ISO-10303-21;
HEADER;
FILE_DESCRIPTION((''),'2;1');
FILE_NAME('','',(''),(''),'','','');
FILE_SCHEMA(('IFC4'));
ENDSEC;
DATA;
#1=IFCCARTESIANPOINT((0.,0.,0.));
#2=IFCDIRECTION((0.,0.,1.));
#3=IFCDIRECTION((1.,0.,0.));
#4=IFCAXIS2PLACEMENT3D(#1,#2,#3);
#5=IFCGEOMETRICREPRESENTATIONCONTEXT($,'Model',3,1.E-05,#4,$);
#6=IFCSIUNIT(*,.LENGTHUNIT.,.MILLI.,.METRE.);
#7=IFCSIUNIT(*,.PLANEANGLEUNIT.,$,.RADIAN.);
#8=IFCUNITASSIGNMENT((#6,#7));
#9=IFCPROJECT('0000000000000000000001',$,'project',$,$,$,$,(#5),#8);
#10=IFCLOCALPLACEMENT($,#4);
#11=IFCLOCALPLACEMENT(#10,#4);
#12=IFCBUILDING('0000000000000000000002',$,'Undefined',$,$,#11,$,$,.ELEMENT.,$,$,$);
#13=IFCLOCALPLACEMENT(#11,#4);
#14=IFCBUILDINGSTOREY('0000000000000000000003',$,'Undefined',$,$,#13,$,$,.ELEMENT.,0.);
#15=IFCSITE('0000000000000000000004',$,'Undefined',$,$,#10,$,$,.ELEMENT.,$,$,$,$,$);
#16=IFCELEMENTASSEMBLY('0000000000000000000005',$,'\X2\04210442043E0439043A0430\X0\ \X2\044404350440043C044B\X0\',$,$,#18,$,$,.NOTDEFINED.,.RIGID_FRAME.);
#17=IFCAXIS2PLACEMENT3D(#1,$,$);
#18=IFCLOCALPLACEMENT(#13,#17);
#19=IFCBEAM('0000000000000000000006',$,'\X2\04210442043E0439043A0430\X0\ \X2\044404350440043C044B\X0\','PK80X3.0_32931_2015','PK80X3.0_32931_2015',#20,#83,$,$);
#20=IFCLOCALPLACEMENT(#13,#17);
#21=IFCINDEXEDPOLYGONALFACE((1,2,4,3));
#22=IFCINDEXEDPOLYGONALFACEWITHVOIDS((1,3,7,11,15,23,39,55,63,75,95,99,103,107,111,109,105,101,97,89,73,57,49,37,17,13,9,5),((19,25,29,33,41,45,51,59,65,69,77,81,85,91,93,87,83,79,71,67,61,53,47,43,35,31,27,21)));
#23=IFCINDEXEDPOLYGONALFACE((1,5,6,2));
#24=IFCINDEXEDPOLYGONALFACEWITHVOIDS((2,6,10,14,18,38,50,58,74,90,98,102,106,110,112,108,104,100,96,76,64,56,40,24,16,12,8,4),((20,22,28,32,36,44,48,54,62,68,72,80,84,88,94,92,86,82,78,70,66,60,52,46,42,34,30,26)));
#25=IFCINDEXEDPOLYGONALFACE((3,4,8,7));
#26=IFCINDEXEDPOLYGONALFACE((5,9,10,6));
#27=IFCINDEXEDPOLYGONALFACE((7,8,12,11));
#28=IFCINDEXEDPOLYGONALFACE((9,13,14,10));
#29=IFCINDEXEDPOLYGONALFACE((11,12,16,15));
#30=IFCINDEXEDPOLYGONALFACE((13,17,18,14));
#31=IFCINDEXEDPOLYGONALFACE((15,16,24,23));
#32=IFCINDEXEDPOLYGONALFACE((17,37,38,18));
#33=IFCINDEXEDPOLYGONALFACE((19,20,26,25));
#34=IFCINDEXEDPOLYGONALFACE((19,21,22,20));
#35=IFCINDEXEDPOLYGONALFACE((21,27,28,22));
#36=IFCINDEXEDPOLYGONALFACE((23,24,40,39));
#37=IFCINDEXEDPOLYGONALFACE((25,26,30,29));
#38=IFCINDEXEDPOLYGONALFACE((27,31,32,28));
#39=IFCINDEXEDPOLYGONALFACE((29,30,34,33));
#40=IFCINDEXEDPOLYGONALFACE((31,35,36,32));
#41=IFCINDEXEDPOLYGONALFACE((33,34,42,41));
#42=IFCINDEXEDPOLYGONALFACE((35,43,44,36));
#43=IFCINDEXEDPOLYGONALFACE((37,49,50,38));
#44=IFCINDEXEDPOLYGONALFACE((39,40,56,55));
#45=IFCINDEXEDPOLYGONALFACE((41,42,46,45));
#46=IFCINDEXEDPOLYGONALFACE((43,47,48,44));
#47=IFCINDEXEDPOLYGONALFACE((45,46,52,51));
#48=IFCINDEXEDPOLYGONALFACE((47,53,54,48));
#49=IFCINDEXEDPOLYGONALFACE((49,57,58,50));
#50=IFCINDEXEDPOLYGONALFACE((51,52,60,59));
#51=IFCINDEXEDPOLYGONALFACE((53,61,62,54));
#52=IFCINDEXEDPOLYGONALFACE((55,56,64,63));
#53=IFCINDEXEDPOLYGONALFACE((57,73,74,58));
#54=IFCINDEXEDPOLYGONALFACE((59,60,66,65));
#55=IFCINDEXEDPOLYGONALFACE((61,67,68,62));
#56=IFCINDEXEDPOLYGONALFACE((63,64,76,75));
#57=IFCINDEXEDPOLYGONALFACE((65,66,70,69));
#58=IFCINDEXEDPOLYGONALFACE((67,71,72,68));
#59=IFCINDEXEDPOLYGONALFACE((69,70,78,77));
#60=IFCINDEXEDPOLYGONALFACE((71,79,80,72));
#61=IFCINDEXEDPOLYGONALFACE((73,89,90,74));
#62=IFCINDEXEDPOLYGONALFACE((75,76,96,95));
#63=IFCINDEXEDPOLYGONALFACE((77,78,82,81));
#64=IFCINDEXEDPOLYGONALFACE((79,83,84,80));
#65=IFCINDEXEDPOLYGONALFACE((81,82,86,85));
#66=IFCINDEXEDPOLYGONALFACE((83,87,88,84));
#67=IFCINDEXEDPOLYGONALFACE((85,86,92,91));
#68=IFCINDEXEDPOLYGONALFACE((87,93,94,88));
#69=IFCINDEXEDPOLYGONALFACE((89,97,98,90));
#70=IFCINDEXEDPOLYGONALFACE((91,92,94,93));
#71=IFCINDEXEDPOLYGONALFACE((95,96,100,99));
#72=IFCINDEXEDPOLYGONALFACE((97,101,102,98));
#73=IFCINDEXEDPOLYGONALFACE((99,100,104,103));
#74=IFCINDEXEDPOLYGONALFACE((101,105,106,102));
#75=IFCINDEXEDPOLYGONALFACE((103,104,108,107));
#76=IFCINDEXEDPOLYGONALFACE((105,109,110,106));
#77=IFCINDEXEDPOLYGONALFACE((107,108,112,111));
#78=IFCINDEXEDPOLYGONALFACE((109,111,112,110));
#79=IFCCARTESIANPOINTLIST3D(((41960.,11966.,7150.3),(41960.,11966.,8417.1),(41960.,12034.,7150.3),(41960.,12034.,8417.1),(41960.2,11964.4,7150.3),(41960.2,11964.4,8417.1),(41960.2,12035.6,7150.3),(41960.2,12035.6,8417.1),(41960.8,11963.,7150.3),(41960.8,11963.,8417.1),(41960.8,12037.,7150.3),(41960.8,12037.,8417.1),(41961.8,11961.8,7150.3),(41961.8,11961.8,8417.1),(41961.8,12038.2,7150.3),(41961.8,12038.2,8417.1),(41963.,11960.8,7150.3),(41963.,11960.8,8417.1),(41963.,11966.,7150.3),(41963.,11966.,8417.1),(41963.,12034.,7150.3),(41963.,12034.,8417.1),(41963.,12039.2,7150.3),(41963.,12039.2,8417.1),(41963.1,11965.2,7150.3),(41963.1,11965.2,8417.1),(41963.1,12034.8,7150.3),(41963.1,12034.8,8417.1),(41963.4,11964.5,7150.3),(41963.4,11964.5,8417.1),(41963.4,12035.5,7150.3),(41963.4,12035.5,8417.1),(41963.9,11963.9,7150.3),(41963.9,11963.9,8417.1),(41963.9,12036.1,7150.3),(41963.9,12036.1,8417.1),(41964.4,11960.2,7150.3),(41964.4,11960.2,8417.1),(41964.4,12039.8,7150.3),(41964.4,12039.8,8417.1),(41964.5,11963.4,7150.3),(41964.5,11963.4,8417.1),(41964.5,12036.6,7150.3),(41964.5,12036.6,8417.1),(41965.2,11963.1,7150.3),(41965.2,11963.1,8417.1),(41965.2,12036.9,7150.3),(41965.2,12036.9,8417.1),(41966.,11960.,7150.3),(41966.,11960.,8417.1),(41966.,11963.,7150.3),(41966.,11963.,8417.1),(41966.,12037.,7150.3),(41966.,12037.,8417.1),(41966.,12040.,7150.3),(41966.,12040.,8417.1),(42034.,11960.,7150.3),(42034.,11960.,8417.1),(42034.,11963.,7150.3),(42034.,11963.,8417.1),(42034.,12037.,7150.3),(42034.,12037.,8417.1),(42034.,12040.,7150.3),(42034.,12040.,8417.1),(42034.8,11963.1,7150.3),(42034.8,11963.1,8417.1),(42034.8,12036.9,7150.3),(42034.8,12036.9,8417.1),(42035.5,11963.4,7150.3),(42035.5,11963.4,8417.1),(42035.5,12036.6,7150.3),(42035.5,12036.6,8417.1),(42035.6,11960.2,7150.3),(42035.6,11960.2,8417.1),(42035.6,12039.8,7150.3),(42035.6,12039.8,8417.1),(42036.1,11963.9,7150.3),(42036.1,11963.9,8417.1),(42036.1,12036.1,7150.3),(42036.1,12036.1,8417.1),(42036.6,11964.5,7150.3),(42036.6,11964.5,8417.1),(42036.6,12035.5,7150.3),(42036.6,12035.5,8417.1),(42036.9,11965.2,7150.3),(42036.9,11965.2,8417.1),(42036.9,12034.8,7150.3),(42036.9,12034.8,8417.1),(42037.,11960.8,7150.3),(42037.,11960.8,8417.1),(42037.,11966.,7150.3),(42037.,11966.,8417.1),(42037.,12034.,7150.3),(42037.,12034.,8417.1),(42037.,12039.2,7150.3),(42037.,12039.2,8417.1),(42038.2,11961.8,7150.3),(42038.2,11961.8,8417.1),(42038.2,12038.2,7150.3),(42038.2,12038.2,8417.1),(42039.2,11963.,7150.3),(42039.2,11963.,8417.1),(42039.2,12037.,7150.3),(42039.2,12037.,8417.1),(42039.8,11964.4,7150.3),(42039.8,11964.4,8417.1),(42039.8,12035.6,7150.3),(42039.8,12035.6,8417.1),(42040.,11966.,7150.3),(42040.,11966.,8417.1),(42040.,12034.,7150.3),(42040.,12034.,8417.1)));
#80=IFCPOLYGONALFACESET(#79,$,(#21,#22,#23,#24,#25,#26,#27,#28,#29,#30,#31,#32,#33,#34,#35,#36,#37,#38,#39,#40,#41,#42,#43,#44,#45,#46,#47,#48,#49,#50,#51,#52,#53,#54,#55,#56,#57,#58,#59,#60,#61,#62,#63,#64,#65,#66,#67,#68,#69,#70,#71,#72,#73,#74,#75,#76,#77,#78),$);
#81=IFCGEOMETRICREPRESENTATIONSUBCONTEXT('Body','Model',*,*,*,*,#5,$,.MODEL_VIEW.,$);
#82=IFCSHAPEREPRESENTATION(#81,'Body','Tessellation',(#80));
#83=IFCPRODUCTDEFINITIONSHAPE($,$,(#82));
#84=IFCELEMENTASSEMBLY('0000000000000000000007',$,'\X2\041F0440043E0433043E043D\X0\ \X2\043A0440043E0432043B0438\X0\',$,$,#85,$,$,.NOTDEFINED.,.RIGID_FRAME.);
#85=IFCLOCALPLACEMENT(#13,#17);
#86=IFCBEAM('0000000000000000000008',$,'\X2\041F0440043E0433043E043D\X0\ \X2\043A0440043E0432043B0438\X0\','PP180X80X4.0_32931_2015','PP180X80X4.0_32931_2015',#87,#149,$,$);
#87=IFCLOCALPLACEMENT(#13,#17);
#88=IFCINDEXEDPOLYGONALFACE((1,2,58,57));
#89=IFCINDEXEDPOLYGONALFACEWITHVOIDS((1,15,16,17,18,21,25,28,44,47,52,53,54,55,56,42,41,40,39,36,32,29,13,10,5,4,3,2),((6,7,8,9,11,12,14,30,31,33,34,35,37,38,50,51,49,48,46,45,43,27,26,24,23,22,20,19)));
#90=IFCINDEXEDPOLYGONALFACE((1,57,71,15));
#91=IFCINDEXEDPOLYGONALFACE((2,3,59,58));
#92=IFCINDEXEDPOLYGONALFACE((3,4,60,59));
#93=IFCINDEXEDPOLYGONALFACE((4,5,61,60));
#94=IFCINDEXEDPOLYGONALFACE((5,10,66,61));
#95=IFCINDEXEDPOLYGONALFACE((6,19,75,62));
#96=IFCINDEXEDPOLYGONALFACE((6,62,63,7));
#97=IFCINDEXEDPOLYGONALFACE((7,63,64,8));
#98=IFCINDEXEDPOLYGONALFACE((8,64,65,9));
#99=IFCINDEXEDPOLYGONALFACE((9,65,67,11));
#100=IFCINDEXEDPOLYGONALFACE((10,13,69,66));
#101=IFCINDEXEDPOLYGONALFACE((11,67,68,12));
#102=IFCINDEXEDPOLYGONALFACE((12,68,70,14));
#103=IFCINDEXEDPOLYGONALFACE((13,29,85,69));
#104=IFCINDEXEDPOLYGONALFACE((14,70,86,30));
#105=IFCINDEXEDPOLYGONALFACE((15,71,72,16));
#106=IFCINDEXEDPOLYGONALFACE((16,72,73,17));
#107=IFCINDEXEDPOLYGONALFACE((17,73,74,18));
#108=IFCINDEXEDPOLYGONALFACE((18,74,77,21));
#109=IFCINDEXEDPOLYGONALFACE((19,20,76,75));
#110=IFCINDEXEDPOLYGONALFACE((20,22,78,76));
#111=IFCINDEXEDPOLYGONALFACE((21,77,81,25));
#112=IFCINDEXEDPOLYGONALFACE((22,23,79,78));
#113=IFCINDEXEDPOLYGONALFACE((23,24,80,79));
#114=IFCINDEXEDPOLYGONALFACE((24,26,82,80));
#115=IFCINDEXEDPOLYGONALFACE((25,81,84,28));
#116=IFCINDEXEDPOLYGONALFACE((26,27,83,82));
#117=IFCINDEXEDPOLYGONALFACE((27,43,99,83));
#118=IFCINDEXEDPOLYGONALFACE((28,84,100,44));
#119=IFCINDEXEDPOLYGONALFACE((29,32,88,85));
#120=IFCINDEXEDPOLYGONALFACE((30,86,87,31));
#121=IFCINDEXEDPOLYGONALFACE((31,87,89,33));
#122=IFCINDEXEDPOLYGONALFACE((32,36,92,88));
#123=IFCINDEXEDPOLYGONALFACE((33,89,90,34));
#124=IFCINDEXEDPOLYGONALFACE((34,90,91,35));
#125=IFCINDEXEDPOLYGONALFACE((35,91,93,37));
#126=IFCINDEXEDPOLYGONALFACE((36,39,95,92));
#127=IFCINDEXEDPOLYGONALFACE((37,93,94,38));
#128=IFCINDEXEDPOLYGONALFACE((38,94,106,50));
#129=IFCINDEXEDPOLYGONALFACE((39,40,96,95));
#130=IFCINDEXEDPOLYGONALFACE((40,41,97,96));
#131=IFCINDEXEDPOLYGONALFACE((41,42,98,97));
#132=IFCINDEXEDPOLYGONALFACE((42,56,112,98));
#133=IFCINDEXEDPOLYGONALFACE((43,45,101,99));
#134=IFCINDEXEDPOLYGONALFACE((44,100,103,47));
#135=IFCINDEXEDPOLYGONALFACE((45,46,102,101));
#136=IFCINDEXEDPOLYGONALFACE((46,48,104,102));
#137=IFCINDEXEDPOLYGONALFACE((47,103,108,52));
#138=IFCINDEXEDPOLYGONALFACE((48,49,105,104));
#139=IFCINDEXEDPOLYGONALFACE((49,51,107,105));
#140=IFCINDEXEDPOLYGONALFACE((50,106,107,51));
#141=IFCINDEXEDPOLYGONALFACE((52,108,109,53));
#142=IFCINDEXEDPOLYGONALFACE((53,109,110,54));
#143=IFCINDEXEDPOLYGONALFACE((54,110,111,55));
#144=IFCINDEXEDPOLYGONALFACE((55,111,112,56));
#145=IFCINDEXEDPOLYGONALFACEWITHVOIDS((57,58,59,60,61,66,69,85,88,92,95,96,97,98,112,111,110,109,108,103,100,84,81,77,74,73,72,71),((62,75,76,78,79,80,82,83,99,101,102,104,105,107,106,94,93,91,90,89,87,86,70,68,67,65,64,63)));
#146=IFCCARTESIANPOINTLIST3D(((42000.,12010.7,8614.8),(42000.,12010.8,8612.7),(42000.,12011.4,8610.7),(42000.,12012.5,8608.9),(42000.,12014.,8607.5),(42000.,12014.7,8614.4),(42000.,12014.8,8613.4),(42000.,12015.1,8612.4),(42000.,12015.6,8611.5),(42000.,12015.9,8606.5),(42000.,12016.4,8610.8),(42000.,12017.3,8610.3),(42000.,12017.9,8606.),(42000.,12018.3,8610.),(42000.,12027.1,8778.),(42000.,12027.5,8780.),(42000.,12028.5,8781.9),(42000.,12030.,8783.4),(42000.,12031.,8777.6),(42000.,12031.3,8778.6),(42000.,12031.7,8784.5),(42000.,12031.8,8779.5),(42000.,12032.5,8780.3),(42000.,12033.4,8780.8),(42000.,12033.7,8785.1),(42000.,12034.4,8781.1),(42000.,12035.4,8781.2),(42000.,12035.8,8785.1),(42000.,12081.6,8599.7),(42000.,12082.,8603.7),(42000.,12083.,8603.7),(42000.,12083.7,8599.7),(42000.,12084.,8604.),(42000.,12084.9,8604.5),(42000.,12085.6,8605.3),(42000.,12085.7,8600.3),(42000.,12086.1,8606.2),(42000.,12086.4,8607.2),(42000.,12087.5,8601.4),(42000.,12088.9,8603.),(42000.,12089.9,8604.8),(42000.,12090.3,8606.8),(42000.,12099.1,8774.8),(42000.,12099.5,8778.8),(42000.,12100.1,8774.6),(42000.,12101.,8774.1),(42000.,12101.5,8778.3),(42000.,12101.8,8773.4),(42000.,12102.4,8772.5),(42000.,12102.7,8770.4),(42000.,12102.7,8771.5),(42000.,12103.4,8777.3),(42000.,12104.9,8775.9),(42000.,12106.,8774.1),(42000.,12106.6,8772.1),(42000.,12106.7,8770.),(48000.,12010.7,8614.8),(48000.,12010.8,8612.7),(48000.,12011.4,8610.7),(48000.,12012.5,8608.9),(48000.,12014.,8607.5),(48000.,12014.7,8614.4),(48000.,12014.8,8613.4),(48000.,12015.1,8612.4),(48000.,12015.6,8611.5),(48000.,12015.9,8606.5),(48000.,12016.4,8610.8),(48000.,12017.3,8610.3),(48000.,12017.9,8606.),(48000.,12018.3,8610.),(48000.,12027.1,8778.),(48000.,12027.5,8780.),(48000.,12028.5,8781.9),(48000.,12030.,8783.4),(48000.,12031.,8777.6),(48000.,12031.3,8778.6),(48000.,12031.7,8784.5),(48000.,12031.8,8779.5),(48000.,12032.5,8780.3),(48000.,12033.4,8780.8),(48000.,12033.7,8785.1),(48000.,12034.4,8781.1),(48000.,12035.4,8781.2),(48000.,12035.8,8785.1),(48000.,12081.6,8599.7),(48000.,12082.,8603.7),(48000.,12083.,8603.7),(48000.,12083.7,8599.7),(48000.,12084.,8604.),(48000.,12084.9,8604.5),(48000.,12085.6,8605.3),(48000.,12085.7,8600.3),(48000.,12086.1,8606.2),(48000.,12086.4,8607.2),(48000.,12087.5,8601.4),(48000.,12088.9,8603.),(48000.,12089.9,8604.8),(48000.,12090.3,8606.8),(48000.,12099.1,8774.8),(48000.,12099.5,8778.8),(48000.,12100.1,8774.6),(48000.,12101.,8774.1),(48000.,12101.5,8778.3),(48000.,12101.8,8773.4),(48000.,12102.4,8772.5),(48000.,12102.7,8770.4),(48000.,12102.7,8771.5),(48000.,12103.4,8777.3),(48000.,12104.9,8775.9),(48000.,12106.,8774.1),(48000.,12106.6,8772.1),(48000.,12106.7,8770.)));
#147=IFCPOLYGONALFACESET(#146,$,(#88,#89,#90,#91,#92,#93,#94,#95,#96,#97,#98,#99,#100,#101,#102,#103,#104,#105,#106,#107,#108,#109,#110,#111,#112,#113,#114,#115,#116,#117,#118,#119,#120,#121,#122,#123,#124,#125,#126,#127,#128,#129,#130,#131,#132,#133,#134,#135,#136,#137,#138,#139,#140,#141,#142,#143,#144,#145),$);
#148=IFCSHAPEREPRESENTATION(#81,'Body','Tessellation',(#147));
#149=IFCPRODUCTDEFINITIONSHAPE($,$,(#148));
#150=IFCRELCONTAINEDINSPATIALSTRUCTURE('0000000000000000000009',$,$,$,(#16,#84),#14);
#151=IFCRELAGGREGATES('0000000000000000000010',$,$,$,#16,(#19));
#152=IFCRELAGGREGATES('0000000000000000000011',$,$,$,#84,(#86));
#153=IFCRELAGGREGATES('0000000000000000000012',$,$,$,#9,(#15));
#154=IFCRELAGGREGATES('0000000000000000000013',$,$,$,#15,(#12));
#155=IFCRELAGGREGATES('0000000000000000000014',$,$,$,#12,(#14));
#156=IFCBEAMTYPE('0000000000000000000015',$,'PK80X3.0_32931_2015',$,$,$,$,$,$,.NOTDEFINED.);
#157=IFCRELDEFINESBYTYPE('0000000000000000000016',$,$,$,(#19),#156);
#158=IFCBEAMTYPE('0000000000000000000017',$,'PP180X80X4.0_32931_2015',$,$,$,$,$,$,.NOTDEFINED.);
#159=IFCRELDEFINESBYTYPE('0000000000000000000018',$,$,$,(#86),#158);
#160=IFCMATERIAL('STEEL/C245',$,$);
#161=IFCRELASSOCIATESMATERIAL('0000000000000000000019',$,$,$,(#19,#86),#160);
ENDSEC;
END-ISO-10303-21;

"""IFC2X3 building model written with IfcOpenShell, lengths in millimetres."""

from ifc_helpers import new_model, si_unit, frame, origin_with_axes, origin_2d_with_axis, place, context, subcontext, project, spatial, hollow_rectangle, extrude, material, type_object, element, aggregate, save


model = new_model("IFC2X3")

# Units and contexts
model_context = context("Model", 3, precision=1e-05, world=origin_with_axes())
body_context = subcontext(model_context, "Body", "Model", "MODEL_VIEW")
ifc_project = project(units=[si_unit("LENGTHUNIT", "METRE", prefix="MILLI"), si_unit("PLANEANGLEUNIT", "RADIAN")], contexts=[model_context])

# Site, building, storey
site_placement = place(None, origin_with_axes())
site = spatial("IfcSite", under=ifc_project, at=site_placement, Name="Undefined", CompositionType="ELEMENT")
building_placement = place(site_placement, origin_with_axes())
building = spatial("IfcBuilding", under=site, at=building_placement, Name="Undefined", CompositionType="ELEMENT")
storey_placement = place(building_placement, origin_with_axes())
storey = spatial("IfcBuildingStorey", under=building, at=storey_placement, Name="Undefined", CompositionType="ELEMENT", Elevation=0.0)

# Element assemblies, beams
ifc_material_1 = material(Name="STEEL/C245")
assembly_1_placement = place(storey_placement, origin_with_axes())
assembly_1 = element("IfcElementAssembly", 1, at=assembly_1_placement, inside=storey, Name="Стойка фермы", AssemblyPlace="NOTDEFINED", PredefinedType="RIGID_FRAME")
beam_type_1 = type_object("IfcBeamType", Name="PK80X3.0_32931_2015", PredefinedType="NOTDEFINED")
beam_1_placement = place(assembly_1_placement, frame((42000.0, 12000.0, 8417.1), z_axis=(1.0, 0.0, 0.0), x_axis=(0.0, 0.0, -1.0)))
beam_1 = element("IfcBeam", 2, at=beam_1_placement, type_object=beam_type_1, material=ifc_material_1, Name="Стойка фермы", Description="PK80X3.0_32931_2015", ObjectType="PK80X3.0_32931_2015", context=body_context, shape_type="SweptSolid", body=[
    extrude(hollow_rectangle(XDim=80.0, YDim=80.0, WallThickness=3.0, InnerFilletRadius=3.0, OuterFilletRadius=6.0, at=origin_2d_with_axis()), frame((1266.8, 0.0, 0.0), z_axis=(-1.0, 0.0, 0.0), x_axis=(0.0, -1.0, 0.0)), (0.0, 0.0, 1.0), 1266.8),
])
aggregate(assembly_1, [beam_1])
assembly_2_placement = place(storey_placement, origin_with_axes())
assembly_2 = element("IfcElementAssembly", 3, at=assembly_2_placement, inside=storey, Name="Прогон кровли", AssemblyPlace="NOTDEFINED", PredefinedType="RIGID_FRAME")
beam_type_2 = type_object("IfcBeamType", Name="PP180X80X4.0_32931_2015", PredefinedType="NOTDEFINED")
beam_2_placement = place(assembly_2_placement, frame((42000.0, 12058.7, 8692.4), z_axis=(0.0, 0.099504, 0.995037), x_axis=(1.0, 0.0, 0.0)))
beam_2 = element("IfcBeam", 4, at=beam_2_placement, type_object=beam_type_2, material=ifc_material_1, Name="Прогон кровли", Description="PP180X80X4.0_32931_2015", ObjectType="PP180X80X4.0_32931_2015", context=body_context, shape_type="SweptSolid", body=[
    extrude(hollow_rectangle(XDim=80.0, YDim=180.0, WallThickness=4.0, InnerFilletRadius=4.0, OuterFilletRadius=8.0, at=origin_2d_with_axis()), frame((6000.0, 0.0, 0.0), z_axis=(-1.0, 0.0, 0.0), x_axis=(0.0, -1.0, 0.0)), (0.0, 0.0, 1.0), 6000.0),
])
aggregate(assembly_2, [beam_2])

save(model, "model.ifc")
